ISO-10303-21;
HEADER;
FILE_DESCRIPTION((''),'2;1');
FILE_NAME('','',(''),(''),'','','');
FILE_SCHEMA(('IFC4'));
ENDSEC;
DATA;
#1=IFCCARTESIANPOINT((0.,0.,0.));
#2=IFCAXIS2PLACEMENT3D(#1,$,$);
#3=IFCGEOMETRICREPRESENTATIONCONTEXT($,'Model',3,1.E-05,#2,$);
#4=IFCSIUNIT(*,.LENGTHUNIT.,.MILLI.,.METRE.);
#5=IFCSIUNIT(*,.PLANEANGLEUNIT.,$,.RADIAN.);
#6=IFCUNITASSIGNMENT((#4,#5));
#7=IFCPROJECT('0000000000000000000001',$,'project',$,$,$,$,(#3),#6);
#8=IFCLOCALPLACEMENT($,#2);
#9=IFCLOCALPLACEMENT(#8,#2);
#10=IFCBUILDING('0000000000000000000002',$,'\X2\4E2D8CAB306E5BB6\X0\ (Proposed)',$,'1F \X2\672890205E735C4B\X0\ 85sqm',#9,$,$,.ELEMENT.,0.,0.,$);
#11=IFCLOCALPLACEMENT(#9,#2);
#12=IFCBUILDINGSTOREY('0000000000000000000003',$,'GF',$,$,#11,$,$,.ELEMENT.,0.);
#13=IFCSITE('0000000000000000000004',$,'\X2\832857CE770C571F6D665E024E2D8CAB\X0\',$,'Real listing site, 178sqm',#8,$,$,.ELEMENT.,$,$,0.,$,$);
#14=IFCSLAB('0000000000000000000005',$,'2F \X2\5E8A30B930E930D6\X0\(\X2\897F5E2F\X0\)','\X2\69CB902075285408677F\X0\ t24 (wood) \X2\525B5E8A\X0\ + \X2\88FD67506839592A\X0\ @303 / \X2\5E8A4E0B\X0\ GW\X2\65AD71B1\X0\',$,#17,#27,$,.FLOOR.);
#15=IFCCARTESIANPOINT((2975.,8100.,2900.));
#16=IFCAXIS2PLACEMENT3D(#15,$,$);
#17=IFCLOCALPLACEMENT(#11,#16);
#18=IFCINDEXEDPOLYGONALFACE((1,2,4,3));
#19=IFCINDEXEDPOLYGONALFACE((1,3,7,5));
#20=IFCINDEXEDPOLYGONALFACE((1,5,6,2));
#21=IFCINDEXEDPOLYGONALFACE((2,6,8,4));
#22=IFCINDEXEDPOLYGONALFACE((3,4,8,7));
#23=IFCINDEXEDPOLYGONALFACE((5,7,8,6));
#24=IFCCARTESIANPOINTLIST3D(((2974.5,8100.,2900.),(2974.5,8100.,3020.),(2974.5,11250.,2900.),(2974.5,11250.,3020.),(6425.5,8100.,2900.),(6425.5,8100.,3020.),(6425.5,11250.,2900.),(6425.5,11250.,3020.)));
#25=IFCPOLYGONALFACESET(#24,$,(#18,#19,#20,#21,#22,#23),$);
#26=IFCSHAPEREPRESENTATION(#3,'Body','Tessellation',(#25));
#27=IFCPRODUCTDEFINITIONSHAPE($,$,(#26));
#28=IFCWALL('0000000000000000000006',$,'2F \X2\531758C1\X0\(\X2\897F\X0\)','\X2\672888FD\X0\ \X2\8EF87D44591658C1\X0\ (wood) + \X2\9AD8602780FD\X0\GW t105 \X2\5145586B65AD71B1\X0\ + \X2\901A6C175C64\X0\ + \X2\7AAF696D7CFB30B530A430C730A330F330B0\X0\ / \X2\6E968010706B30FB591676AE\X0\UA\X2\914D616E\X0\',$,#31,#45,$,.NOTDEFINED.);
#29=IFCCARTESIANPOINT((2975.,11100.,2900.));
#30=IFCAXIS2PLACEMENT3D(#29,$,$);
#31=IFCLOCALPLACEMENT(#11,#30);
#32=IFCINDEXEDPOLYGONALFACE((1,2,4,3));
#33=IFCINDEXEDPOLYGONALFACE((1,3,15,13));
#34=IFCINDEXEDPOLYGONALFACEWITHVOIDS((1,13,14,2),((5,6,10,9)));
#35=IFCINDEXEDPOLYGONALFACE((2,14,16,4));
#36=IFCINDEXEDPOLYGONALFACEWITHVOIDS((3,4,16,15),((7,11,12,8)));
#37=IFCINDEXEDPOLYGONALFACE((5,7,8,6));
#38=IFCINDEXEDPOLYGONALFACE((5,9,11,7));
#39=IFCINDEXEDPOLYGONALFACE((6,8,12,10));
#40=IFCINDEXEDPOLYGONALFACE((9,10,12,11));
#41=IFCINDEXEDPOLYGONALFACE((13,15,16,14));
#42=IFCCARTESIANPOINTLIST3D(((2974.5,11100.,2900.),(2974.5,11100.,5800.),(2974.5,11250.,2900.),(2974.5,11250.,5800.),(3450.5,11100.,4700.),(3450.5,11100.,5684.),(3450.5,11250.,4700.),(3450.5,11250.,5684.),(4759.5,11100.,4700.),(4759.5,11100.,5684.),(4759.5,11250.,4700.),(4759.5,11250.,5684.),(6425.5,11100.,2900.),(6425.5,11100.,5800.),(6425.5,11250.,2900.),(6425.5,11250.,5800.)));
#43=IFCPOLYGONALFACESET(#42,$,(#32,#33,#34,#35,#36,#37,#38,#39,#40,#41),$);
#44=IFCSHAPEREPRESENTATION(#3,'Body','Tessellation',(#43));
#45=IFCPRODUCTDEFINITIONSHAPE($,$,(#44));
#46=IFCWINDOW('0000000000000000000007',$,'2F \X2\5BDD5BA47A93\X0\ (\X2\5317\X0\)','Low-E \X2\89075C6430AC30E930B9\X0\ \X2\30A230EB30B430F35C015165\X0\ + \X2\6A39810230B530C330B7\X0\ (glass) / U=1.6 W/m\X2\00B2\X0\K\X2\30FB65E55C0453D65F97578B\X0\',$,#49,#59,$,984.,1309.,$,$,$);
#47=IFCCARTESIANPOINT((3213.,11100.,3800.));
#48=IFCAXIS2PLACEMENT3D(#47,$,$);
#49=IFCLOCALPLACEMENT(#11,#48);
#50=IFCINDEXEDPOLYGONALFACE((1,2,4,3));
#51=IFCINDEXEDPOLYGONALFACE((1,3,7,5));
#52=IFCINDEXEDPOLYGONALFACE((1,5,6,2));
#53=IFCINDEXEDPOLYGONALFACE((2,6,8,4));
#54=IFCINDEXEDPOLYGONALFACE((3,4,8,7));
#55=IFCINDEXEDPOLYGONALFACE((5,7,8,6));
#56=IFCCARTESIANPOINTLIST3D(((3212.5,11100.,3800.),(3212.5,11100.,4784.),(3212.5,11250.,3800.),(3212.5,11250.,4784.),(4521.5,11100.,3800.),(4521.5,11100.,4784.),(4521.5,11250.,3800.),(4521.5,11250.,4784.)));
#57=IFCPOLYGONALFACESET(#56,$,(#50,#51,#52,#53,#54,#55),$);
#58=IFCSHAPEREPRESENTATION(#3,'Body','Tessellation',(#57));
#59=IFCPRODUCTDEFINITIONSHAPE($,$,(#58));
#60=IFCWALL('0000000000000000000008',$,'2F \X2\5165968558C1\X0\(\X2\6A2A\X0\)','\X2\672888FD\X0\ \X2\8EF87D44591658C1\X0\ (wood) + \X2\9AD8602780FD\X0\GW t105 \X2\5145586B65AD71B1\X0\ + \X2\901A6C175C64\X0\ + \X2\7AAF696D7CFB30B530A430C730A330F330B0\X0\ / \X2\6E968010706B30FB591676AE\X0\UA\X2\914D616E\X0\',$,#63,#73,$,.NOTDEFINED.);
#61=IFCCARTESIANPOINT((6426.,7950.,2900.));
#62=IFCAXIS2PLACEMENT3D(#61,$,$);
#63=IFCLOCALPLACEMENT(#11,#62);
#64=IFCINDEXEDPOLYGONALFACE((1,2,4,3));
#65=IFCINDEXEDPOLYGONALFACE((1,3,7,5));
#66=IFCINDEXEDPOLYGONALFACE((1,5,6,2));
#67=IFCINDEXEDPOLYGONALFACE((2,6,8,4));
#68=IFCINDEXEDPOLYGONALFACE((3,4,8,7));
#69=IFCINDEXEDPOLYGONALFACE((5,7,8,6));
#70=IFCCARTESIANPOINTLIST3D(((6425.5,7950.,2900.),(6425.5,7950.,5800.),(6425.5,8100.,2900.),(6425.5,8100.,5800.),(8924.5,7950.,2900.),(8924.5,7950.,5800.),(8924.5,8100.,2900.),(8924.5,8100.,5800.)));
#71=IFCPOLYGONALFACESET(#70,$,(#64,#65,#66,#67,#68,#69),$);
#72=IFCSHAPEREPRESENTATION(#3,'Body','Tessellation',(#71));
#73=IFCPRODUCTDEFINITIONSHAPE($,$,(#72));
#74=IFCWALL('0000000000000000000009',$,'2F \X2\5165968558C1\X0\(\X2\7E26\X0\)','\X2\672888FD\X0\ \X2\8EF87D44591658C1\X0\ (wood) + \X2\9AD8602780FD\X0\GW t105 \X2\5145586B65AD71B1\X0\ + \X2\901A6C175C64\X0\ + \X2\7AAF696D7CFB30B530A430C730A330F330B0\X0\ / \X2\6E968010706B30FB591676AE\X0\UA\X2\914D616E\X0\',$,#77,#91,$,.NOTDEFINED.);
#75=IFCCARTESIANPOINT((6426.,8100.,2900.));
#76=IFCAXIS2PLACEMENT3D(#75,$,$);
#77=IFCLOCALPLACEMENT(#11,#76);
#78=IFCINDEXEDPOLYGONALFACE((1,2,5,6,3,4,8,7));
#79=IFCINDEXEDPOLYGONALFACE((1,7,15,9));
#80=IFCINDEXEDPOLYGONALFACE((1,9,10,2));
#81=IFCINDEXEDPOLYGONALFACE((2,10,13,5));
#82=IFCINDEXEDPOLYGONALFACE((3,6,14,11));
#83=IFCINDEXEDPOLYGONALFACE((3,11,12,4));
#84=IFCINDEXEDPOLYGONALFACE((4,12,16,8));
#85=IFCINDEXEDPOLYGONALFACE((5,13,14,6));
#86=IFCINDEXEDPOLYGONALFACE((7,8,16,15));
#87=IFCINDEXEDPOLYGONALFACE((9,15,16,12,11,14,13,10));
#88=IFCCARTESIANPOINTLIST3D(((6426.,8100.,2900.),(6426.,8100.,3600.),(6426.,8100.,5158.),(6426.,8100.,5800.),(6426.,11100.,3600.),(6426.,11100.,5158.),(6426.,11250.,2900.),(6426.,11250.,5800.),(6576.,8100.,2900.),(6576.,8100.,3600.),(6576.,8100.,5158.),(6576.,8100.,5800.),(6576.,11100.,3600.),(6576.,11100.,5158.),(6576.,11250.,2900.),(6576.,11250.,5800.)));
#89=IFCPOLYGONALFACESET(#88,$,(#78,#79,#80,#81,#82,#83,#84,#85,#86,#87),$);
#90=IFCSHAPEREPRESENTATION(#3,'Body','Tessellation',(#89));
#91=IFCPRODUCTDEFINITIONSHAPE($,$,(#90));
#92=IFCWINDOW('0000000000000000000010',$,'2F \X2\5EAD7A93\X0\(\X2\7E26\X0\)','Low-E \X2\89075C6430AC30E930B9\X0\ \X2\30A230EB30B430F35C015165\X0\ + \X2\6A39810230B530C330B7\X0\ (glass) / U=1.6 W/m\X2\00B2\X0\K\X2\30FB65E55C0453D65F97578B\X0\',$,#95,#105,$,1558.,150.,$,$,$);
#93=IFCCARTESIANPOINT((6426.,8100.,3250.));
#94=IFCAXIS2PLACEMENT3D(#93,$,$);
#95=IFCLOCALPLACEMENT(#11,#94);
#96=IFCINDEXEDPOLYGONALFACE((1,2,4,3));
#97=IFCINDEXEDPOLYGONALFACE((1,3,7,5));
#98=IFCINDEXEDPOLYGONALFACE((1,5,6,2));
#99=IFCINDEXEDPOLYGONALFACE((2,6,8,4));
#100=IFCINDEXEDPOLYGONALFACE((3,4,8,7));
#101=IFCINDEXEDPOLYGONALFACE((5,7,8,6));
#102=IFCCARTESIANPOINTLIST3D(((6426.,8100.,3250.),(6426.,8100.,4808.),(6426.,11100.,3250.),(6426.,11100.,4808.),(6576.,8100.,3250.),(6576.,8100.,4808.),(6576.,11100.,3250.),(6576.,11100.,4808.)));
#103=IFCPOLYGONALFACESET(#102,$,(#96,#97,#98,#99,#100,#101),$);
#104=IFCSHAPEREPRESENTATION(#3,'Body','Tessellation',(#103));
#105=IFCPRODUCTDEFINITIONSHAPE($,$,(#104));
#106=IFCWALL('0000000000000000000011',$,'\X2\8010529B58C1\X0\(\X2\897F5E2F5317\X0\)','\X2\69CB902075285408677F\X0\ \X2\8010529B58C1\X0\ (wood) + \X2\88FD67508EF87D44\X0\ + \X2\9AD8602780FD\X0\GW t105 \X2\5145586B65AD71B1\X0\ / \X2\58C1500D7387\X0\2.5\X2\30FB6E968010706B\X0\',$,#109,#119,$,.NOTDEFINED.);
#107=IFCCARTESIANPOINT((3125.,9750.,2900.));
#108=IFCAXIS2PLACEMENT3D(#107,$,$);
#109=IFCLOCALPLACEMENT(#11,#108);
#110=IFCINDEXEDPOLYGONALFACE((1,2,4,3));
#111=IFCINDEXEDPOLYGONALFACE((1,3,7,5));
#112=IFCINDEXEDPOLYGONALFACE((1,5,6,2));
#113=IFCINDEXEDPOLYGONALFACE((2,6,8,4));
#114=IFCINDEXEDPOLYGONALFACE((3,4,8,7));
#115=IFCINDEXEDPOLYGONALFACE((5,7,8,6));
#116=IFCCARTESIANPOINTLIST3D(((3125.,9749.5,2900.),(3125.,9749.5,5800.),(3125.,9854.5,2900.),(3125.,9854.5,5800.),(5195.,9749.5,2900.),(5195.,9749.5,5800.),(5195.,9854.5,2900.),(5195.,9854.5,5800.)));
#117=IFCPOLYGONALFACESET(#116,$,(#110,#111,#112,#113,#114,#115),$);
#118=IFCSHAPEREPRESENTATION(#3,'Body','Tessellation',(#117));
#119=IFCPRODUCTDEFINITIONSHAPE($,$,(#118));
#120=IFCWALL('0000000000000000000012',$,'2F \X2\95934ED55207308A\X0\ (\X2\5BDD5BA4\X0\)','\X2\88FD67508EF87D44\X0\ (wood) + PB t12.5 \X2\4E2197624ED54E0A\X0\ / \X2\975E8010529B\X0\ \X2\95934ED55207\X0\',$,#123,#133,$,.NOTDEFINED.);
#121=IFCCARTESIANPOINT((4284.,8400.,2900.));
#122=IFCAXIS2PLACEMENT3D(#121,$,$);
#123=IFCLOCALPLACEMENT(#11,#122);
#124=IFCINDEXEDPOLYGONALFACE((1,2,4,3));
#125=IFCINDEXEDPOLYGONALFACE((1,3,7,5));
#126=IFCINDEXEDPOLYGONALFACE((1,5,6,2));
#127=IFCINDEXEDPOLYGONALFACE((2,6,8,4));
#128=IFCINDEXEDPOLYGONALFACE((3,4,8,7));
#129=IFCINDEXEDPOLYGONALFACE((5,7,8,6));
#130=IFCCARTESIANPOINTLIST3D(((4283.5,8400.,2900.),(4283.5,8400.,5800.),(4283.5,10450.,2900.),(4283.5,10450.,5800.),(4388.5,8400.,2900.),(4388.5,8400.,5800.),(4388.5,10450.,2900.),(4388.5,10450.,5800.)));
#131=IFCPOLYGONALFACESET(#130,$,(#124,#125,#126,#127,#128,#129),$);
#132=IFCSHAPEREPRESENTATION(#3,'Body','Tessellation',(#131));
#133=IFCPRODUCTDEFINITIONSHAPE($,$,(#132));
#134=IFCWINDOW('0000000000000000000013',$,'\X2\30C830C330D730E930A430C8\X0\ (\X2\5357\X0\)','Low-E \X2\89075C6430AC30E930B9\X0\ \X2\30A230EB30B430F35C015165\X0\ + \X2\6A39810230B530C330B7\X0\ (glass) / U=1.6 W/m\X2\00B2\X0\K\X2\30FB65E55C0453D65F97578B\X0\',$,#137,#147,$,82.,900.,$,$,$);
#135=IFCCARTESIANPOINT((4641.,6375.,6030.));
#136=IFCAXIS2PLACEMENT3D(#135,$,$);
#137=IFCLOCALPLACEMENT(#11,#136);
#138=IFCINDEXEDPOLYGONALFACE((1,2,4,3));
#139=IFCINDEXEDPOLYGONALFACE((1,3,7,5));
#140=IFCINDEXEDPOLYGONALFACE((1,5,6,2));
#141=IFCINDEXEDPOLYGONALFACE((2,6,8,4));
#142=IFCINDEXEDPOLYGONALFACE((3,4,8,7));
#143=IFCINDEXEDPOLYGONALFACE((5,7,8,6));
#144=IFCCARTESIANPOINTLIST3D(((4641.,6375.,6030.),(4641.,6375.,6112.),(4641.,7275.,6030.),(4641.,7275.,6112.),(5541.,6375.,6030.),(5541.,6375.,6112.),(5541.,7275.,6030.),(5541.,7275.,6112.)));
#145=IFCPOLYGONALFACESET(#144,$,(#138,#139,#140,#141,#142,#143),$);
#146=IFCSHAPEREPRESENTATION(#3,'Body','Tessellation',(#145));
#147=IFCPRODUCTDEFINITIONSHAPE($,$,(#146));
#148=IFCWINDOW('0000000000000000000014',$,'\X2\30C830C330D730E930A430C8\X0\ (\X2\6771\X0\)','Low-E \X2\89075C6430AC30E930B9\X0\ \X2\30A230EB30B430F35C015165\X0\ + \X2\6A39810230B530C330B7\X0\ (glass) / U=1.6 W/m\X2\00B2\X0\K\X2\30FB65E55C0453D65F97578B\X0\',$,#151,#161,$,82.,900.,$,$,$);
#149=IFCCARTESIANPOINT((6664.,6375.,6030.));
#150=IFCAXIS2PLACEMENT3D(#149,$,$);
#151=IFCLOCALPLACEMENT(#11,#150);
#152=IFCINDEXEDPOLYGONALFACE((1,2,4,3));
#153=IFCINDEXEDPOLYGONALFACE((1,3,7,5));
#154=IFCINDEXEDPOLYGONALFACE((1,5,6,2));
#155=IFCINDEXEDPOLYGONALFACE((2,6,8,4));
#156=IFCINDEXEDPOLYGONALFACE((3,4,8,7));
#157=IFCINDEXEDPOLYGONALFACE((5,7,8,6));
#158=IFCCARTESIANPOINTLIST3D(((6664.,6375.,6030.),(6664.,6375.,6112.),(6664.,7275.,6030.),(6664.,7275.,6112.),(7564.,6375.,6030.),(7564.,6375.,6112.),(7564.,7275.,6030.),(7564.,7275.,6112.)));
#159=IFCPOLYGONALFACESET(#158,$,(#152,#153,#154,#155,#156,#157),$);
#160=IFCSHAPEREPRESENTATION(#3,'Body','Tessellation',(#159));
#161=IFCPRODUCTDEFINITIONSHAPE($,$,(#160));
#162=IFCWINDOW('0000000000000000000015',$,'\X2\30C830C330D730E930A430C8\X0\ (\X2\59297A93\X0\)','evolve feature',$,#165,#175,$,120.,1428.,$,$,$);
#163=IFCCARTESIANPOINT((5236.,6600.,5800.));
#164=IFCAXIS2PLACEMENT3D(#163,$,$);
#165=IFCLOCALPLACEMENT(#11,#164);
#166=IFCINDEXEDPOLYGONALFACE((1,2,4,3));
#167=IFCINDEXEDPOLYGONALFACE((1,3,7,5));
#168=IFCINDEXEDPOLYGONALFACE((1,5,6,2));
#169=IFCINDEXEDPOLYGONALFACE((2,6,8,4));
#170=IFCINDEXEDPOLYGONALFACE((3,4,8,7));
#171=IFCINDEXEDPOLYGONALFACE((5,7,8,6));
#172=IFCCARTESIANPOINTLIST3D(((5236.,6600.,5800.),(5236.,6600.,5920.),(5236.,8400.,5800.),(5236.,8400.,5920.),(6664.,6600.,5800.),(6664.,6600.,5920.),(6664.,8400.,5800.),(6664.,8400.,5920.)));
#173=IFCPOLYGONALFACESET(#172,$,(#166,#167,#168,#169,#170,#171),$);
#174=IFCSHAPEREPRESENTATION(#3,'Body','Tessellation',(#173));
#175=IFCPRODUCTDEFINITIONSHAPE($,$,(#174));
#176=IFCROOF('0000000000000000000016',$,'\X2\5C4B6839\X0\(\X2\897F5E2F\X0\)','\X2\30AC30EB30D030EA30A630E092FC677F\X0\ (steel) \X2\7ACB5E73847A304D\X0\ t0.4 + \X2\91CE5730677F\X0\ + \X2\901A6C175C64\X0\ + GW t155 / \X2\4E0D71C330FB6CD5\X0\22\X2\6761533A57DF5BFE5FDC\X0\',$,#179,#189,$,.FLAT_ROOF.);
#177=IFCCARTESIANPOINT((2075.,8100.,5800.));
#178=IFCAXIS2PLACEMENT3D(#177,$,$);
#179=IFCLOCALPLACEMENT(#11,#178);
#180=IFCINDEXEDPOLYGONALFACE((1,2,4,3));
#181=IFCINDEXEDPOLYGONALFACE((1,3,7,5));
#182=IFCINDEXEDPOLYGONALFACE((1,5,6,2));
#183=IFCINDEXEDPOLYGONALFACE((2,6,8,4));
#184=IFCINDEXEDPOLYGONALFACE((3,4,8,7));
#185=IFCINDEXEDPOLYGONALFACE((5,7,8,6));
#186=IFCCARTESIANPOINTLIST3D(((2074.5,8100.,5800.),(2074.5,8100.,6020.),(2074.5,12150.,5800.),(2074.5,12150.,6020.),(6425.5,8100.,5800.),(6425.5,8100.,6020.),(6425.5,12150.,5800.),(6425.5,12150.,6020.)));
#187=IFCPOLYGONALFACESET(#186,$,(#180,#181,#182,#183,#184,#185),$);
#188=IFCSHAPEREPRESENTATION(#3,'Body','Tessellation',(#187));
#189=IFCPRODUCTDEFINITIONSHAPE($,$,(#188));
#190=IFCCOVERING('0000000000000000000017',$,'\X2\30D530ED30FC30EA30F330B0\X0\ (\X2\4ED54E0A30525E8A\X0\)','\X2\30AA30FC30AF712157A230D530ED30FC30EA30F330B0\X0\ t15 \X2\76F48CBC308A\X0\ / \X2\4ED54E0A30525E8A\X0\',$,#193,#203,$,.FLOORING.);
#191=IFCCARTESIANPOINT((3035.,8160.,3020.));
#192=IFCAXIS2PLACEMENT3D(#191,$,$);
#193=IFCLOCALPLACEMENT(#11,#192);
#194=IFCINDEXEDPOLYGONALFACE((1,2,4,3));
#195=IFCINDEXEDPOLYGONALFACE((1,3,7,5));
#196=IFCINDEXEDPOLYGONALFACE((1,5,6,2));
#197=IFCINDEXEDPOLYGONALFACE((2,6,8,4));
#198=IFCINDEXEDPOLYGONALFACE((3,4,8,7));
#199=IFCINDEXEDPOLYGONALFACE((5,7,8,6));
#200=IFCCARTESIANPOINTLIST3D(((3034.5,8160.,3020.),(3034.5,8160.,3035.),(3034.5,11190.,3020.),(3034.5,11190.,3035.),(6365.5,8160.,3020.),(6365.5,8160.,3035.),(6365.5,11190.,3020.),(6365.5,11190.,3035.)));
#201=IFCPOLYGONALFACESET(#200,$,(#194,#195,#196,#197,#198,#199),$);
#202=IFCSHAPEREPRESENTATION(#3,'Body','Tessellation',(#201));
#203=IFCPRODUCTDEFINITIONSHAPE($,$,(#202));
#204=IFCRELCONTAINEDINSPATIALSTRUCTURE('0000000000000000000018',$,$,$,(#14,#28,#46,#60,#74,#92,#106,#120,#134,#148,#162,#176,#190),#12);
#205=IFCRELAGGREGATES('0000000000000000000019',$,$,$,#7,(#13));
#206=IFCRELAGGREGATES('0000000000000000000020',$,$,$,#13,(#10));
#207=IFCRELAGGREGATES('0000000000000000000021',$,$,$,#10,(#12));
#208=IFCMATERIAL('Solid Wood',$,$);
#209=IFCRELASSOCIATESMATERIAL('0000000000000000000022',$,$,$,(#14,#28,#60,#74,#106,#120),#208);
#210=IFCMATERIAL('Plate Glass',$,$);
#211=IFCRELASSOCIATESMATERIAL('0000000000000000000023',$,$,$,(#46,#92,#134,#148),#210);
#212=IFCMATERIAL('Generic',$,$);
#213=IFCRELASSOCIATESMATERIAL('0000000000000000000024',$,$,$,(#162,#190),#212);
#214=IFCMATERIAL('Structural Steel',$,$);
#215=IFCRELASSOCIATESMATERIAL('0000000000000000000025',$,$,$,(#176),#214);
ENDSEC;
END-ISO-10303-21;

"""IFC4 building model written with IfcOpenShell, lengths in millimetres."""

from ifc_helpers import new_model, si_unit, frame, frame_2d, origin, place, context, project, spatial, rectangle, extrude, material, element, fill, save


model = new_model("IFC4")

# Units and contexts
model_context = context("Model", 3, precision=1e-05, world=origin())
ifc_project = project(units=[si_unit("LENGTHUNIT", "METRE", prefix="MILLI"), si_unit("PLANEANGLEUNIT", "RADIAN")], contexts=[model_context])

# Site, building, storey
site_placement = place(None, origin())
site = spatial("IfcSite", under=ifc_project, at=site_placement, Name="茨城県土浦市中貫", ObjectType="Real listing site, 178sqm", CompositionType="ELEMENT", RefElevation=0.0)
building_placement = place(site_placement, origin())
building = spatial("IfcBuilding", under=site, at=building_placement, Name="中貫の家 (Proposed)", ObjectType="1F 木造平屋 85sqm", CompositionType="ELEMENT", ElevationOfRefHeight=0.0, ElevationOfTerrain=0.0)
storey_placement = place(building_placement, origin())
storey = spatial("IfcBuildingStorey", under=building, at=storey_placement, Name="GF", CompositionType="ELEMENT", Elevation=0.0)

# Slab
ifc_material_1 = material(Name="Solid Wood")
slab_placement = place(storey_placement, frame((2975.0, 8100.0, 2900.0)))
element("IfcSlab", 1, at=slab_placement, inside=storey, material=ifc_material_1, Name="2F 床スラブ(西帯)", Description="構造用合板 t24 (wood) 剛床 + 製材根太 @303 / 床下 GW断熱", PredefinedType="FLOOR", context=model_context, shape_type="SweptSolid", body=[
    extrude(rectangle(XDim=3451.0, YDim=3150.0, at=frame_2d((1725.0, 1575.0))), frame((2975.0, 8100.0, 2900.0)), (0.0, 0.0, 1.0), 120.0),
])

# Wall, opening, window
wall_1_placement = place(storey_placement, frame((2975.0, 11100.0, 2900.0)))
wall_1 = element("IfcWall", 2, at=wall_1_placement, inside=storey, material=ifc_material_1, Name="2F 北壁(西)", Description="木製 軸組外壁 (wood) + 高性能GW t105 充填断熱 + 通気層 + 窯業系サイディング / 準耐火・外皮UA配慮", PredefinedType="NOTDEFINED", context=model_context, shape_type="SweptSolid", body=[
    extrude(rectangle(XDim=3451.0, YDim=150.0, at=frame_2d((1725.0, 75.0))), frame((2975.0, 11100.0, 2900.0)), (0.0, 0.0, 1.0), 2900.0),
])
opening_1_placement = place(storey_placement, frame((3213.0, 11100.0, 3800.0)))
opening_1 = element("IfcOpeningElement", 3, at=opening_1_placement, cuts=wall_1, PredefinedType="NOTDEFINED", context=model_context, shape_type="SweptSolid", body=[
    extrude(rectangle(XDim=1309.0, YDim=150.0, at=frame_2d((654.0, 75.0))), frame((3213.0, 11100.0, 3800.0)), (0.0, 0.0, 1.0), 984.0),
])
ifc_material_2 = material(Name="Plate Glass")
window_1_placement = place(storey_placement, frame((3213.0, 11100.0, 3800.0)))
window_1 = element("IfcWindow", 4, at=window_1_placement, inside=storey, material=ifc_material_2, Name="2F 寝室窓 (北)", Description="Low-E 複層ガラス アルゴン封入 + 樹脂サッシ (glass) / U=1.6 W/m²K・日射取得型", OverallHeight=984.0, OverallWidth=1309.0, context=model_context, shape_type="SweptSolid", body=[
    extrude(rectangle(XDim=1309.0, YDim=150.0, at=frame_2d((654.0, 75.0))), frame((3213.0, 11100.0, 3800.0)), (0.0, 0.0, 1.0), 984.0),
])
fill(opening_1, window_1)

# Wall
wall_2_placement = place(storey_placement, frame((6426.0, 7950.0, 2900.0)))
element("IfcWall", 5, at=wall_2_placement, inside=storey, material=ifc_material_1, Name="2F 入隅壁(横)", Description="木製 軸組外壁 (wood) + 高性能GW t105 充填断熱 + 通気層 + 窯業系サイディング / 準耐火・外皮UA配慮", PredefinedType="NOTDEFINED", context=model_context, shape_type="SweptSolid", body=[
    extrude(rectangle(XDim=2499.0, YDim=150.0, at=frame_2d((1249.0, 75.0))), frame((6426.0, 7950.0, 2900.0)), (0.0, 0.0, 1.0), 2900.0),
])

# Wall, opening, window
wall_3_placement = place(storey_placement, frame((6426.0, 8100.0, 2900.0)))
wall_3 = element("IfcWall", 6, at=wall_3_placement, inside=storey, material=ifc_material_1, Name="2F 入隅壁(縦)", Description="木製 軸組外壁 (wood) + 高性能GW t105 充填断熱 + 通気層 + 窯業系サイディング / 準耐火・外皮UA配慮", PredefinedType="NOTDEFINED", context=model_context, shape_type="SweptSolid", body=[
    extrude(rectangle(XDim=150.0, YDim=3150.0, at=frame_2d((75.0, 1575.0))), frame((6426.0, 8100.0, 2900.0)), (0.0, 0.0, 1.0), 2900.0),
])
opening_2_placement = place(storey_placement, frame((6426.0, 8100.0, 3250.0)))
opening_2 = element("IfcOpeningElement", 7, at=opening_2_placement, cuts=wall_3, PredefinedType="NOTDEFINED", context=model_context, shape_type="SweptSolid", body=[
    extrude(rectangle(XDim=150.0, YDim=3000.0, at=frame_2d((75.0, 1500.0))), frame((6426.0, 8100.0, 3250.0)), (0.0, 0.0, 1.0), 1558.0),
])
window_2_placement = place(storey_placement, frame((6426.0, 8100.0, 3250.0)))
window_2 = element("IfcWindow", 8, at=window_2_placement, inside=storey, material=ifc_material_2, Name="2F 庭窓(縦)", Description="Low-E 複層ガラス アルゴン封入 + 樹脂サッシ (glass) / U=1.6 W/m²K・日射取得型", OverallHeight=1558.0, OverallWidth=150.0, context=model_context, shape_type="SweptSolid", body=[
    extrude(rectangle(XDim=150.0, YDim=3000.0, at=frame_2d((75.0, 1500.0))), frame((6426.0, 8100.0, 3250.0)), (0.0, 0.0, 1.0), 1558.0),
])
fill(opening_2, window_2)

# Walls
wall_4_placement = place(storey_placement, frame((3125.0, 9750.0, 2900.0)))
element("IfcWall", 9, at=wall_4_placement, inside=storey, material=ifc_material_1, Name="耐力壁(西帯北)", Description="構造用合板 耐力壁 (wood) + 製材軸組 + 高性能GW t105 充填断熱 / 壁倍率2.5・準耐火", PredefinedType="NOTDEFINED", context=model_context, shape_type="SweptSolid", body=[
    extrude(rectangle(XDim=2070.0, YDim=105.0, at=frame_2d((1035.0, 52.0))), frame((3125.0, 9750.0, 2900.0)), (0.0, 0.0, 1.0), 2900.0),
])
wall_5_placement = place(storey_placement, frame((4284.0, 8400.0, 2900.0)))
element("IfcWall", 10, at=wall_5_placement, inside=storey, material=ifc_material_1, Name="2F 間仕切り (寝室)", Description="製材軸組 (wood) + PB t12.5 両面仕上 / 非耐力 間仕切", PredefinedType="NOTDEFINED", context=model_context, shape_type="SweptSolid", body=[
    extrude(rectangle(XDim=105.0, YDim=2050.0, at=frame_2d((52.0, 1025.0))), frame((4284.0, 8400.0, 2900.0)), (0.0, 0.0, 1.0), 2900.0),
])

# Windows
window_3_placement = place(storey_placement, frame((4641.0, 6375.0, 6030.0)))
element("IfcWindow", 11, at=window_3_placement, inside=storey, material=ifc_material_2, Name="トップライト (南)", Description="Low-E 複層ガラス アルゴン封入 + 樹脂サッシ (glass) / U=1.6 W/m²K・日射取得型", OverallHeight=82.0, OverallWidth=900.0, context=model_context, shape_type="SweptSolid", body=[
    extrude(rectangle(XDim=900.0, YDim=900.0, at=frame_2d((450.0, 450.0))), frame((4641.0, 6375.0, 6030.0)), (0.0, 0.0, 1.0), 82.0),
])
window_4_placement = place(storey_placement, frame((6664.0, 6375.0, 6030.0)))
element("IfcWindow", 12, at=window_4_placement, inside=storey, material=ifc_material_2, Name="トップライト (東)", Description="Low-E 複層ガラス アルゴン封入 + 樹脂サッシ (glass) / U=1.6 W/m²K・日射取得型", OverallHeight=82.0, OverallWidth=900.0, context=model_context, shape_type="SweptSolid", body=[
    extrude(rectangle(XDim=900.0, YDim=900.0, at=frame_2d((450.0, 450.0))), frame((6664.0, 6375.0, 6030.0)), (0.0, 0.0, 1.0), 82.0),
])
ifc_material_3 = material(Name="Generic")
window_5_placement = place(storey_placement, frame((5236.0, 6600.0, 5800.0)))
element("IfcWindow", 13, at=window_5_placement, inside=storey, material=ifc_material_3, Name="トップライト (天窓)", Description="evolve feature", OverallHeight=120.0, OverallWidth=1428.0, context=model_context, shape_type="SweptSolid", body=[
    extrude(rectangle(XDim=1428.0, YDim=1800.0, at=frame_2d((714.0, 900.0))), frame((5236.0, 6600.0, 5800.0)), (0.0, 0.0, 1.0), 120.0),
])

# Roof
ifc_material_4 = material(Name="Structural Steel")
for number, where, name in (
    (14, (2075.0, 8100.0, 5800.0), "屋根(西帯)"),
):
    element("IfcRoof", number, at=place(storey_placement, frame(where)), inside=storey, material=ifc_material_4, Name=name, Description="ガルバリウム鋼板 (steel) 立平葺き t0.4 + 野地板 + 通気層 + GW t155 / 不燃・法22条区域対応", PredefinedType="FLAT_ROOF", context=model_context, shape_type="SweptSolid", body=[
        extrude(rectangle(XDim=4351.0, YDim=4050.0, at=frame_2d((2175.0, 2025.0))), frame((2075.0, 8100.0, 5800.0)), (0.0, 0.0, 1.0), 220.0),
    ])

# Covering
covering_placement = place(storey_placement, frame((3035.0, 8160.0, 3020.0)))
element("IfcCovering", 15, at=covering_placement, inside=storey, material=ifc_material_3, Name="フローリング (仕上げ床)", Description="オーク無垢フローリング t15 直貼り / 仕上げ床", PredefinedType="FLOORING", context=model_context, shape_type="SweptSolid", body=[
    extrude(rectangle(XDim=3331.0, YDim=3030.0, at=frame_2d((1665.0, 1515.0))), frame((3035.0, 8160.0, 3020.0)), (0.0, 0.0, 1.0), 15.0),
])

save(model, "model.ifc")
